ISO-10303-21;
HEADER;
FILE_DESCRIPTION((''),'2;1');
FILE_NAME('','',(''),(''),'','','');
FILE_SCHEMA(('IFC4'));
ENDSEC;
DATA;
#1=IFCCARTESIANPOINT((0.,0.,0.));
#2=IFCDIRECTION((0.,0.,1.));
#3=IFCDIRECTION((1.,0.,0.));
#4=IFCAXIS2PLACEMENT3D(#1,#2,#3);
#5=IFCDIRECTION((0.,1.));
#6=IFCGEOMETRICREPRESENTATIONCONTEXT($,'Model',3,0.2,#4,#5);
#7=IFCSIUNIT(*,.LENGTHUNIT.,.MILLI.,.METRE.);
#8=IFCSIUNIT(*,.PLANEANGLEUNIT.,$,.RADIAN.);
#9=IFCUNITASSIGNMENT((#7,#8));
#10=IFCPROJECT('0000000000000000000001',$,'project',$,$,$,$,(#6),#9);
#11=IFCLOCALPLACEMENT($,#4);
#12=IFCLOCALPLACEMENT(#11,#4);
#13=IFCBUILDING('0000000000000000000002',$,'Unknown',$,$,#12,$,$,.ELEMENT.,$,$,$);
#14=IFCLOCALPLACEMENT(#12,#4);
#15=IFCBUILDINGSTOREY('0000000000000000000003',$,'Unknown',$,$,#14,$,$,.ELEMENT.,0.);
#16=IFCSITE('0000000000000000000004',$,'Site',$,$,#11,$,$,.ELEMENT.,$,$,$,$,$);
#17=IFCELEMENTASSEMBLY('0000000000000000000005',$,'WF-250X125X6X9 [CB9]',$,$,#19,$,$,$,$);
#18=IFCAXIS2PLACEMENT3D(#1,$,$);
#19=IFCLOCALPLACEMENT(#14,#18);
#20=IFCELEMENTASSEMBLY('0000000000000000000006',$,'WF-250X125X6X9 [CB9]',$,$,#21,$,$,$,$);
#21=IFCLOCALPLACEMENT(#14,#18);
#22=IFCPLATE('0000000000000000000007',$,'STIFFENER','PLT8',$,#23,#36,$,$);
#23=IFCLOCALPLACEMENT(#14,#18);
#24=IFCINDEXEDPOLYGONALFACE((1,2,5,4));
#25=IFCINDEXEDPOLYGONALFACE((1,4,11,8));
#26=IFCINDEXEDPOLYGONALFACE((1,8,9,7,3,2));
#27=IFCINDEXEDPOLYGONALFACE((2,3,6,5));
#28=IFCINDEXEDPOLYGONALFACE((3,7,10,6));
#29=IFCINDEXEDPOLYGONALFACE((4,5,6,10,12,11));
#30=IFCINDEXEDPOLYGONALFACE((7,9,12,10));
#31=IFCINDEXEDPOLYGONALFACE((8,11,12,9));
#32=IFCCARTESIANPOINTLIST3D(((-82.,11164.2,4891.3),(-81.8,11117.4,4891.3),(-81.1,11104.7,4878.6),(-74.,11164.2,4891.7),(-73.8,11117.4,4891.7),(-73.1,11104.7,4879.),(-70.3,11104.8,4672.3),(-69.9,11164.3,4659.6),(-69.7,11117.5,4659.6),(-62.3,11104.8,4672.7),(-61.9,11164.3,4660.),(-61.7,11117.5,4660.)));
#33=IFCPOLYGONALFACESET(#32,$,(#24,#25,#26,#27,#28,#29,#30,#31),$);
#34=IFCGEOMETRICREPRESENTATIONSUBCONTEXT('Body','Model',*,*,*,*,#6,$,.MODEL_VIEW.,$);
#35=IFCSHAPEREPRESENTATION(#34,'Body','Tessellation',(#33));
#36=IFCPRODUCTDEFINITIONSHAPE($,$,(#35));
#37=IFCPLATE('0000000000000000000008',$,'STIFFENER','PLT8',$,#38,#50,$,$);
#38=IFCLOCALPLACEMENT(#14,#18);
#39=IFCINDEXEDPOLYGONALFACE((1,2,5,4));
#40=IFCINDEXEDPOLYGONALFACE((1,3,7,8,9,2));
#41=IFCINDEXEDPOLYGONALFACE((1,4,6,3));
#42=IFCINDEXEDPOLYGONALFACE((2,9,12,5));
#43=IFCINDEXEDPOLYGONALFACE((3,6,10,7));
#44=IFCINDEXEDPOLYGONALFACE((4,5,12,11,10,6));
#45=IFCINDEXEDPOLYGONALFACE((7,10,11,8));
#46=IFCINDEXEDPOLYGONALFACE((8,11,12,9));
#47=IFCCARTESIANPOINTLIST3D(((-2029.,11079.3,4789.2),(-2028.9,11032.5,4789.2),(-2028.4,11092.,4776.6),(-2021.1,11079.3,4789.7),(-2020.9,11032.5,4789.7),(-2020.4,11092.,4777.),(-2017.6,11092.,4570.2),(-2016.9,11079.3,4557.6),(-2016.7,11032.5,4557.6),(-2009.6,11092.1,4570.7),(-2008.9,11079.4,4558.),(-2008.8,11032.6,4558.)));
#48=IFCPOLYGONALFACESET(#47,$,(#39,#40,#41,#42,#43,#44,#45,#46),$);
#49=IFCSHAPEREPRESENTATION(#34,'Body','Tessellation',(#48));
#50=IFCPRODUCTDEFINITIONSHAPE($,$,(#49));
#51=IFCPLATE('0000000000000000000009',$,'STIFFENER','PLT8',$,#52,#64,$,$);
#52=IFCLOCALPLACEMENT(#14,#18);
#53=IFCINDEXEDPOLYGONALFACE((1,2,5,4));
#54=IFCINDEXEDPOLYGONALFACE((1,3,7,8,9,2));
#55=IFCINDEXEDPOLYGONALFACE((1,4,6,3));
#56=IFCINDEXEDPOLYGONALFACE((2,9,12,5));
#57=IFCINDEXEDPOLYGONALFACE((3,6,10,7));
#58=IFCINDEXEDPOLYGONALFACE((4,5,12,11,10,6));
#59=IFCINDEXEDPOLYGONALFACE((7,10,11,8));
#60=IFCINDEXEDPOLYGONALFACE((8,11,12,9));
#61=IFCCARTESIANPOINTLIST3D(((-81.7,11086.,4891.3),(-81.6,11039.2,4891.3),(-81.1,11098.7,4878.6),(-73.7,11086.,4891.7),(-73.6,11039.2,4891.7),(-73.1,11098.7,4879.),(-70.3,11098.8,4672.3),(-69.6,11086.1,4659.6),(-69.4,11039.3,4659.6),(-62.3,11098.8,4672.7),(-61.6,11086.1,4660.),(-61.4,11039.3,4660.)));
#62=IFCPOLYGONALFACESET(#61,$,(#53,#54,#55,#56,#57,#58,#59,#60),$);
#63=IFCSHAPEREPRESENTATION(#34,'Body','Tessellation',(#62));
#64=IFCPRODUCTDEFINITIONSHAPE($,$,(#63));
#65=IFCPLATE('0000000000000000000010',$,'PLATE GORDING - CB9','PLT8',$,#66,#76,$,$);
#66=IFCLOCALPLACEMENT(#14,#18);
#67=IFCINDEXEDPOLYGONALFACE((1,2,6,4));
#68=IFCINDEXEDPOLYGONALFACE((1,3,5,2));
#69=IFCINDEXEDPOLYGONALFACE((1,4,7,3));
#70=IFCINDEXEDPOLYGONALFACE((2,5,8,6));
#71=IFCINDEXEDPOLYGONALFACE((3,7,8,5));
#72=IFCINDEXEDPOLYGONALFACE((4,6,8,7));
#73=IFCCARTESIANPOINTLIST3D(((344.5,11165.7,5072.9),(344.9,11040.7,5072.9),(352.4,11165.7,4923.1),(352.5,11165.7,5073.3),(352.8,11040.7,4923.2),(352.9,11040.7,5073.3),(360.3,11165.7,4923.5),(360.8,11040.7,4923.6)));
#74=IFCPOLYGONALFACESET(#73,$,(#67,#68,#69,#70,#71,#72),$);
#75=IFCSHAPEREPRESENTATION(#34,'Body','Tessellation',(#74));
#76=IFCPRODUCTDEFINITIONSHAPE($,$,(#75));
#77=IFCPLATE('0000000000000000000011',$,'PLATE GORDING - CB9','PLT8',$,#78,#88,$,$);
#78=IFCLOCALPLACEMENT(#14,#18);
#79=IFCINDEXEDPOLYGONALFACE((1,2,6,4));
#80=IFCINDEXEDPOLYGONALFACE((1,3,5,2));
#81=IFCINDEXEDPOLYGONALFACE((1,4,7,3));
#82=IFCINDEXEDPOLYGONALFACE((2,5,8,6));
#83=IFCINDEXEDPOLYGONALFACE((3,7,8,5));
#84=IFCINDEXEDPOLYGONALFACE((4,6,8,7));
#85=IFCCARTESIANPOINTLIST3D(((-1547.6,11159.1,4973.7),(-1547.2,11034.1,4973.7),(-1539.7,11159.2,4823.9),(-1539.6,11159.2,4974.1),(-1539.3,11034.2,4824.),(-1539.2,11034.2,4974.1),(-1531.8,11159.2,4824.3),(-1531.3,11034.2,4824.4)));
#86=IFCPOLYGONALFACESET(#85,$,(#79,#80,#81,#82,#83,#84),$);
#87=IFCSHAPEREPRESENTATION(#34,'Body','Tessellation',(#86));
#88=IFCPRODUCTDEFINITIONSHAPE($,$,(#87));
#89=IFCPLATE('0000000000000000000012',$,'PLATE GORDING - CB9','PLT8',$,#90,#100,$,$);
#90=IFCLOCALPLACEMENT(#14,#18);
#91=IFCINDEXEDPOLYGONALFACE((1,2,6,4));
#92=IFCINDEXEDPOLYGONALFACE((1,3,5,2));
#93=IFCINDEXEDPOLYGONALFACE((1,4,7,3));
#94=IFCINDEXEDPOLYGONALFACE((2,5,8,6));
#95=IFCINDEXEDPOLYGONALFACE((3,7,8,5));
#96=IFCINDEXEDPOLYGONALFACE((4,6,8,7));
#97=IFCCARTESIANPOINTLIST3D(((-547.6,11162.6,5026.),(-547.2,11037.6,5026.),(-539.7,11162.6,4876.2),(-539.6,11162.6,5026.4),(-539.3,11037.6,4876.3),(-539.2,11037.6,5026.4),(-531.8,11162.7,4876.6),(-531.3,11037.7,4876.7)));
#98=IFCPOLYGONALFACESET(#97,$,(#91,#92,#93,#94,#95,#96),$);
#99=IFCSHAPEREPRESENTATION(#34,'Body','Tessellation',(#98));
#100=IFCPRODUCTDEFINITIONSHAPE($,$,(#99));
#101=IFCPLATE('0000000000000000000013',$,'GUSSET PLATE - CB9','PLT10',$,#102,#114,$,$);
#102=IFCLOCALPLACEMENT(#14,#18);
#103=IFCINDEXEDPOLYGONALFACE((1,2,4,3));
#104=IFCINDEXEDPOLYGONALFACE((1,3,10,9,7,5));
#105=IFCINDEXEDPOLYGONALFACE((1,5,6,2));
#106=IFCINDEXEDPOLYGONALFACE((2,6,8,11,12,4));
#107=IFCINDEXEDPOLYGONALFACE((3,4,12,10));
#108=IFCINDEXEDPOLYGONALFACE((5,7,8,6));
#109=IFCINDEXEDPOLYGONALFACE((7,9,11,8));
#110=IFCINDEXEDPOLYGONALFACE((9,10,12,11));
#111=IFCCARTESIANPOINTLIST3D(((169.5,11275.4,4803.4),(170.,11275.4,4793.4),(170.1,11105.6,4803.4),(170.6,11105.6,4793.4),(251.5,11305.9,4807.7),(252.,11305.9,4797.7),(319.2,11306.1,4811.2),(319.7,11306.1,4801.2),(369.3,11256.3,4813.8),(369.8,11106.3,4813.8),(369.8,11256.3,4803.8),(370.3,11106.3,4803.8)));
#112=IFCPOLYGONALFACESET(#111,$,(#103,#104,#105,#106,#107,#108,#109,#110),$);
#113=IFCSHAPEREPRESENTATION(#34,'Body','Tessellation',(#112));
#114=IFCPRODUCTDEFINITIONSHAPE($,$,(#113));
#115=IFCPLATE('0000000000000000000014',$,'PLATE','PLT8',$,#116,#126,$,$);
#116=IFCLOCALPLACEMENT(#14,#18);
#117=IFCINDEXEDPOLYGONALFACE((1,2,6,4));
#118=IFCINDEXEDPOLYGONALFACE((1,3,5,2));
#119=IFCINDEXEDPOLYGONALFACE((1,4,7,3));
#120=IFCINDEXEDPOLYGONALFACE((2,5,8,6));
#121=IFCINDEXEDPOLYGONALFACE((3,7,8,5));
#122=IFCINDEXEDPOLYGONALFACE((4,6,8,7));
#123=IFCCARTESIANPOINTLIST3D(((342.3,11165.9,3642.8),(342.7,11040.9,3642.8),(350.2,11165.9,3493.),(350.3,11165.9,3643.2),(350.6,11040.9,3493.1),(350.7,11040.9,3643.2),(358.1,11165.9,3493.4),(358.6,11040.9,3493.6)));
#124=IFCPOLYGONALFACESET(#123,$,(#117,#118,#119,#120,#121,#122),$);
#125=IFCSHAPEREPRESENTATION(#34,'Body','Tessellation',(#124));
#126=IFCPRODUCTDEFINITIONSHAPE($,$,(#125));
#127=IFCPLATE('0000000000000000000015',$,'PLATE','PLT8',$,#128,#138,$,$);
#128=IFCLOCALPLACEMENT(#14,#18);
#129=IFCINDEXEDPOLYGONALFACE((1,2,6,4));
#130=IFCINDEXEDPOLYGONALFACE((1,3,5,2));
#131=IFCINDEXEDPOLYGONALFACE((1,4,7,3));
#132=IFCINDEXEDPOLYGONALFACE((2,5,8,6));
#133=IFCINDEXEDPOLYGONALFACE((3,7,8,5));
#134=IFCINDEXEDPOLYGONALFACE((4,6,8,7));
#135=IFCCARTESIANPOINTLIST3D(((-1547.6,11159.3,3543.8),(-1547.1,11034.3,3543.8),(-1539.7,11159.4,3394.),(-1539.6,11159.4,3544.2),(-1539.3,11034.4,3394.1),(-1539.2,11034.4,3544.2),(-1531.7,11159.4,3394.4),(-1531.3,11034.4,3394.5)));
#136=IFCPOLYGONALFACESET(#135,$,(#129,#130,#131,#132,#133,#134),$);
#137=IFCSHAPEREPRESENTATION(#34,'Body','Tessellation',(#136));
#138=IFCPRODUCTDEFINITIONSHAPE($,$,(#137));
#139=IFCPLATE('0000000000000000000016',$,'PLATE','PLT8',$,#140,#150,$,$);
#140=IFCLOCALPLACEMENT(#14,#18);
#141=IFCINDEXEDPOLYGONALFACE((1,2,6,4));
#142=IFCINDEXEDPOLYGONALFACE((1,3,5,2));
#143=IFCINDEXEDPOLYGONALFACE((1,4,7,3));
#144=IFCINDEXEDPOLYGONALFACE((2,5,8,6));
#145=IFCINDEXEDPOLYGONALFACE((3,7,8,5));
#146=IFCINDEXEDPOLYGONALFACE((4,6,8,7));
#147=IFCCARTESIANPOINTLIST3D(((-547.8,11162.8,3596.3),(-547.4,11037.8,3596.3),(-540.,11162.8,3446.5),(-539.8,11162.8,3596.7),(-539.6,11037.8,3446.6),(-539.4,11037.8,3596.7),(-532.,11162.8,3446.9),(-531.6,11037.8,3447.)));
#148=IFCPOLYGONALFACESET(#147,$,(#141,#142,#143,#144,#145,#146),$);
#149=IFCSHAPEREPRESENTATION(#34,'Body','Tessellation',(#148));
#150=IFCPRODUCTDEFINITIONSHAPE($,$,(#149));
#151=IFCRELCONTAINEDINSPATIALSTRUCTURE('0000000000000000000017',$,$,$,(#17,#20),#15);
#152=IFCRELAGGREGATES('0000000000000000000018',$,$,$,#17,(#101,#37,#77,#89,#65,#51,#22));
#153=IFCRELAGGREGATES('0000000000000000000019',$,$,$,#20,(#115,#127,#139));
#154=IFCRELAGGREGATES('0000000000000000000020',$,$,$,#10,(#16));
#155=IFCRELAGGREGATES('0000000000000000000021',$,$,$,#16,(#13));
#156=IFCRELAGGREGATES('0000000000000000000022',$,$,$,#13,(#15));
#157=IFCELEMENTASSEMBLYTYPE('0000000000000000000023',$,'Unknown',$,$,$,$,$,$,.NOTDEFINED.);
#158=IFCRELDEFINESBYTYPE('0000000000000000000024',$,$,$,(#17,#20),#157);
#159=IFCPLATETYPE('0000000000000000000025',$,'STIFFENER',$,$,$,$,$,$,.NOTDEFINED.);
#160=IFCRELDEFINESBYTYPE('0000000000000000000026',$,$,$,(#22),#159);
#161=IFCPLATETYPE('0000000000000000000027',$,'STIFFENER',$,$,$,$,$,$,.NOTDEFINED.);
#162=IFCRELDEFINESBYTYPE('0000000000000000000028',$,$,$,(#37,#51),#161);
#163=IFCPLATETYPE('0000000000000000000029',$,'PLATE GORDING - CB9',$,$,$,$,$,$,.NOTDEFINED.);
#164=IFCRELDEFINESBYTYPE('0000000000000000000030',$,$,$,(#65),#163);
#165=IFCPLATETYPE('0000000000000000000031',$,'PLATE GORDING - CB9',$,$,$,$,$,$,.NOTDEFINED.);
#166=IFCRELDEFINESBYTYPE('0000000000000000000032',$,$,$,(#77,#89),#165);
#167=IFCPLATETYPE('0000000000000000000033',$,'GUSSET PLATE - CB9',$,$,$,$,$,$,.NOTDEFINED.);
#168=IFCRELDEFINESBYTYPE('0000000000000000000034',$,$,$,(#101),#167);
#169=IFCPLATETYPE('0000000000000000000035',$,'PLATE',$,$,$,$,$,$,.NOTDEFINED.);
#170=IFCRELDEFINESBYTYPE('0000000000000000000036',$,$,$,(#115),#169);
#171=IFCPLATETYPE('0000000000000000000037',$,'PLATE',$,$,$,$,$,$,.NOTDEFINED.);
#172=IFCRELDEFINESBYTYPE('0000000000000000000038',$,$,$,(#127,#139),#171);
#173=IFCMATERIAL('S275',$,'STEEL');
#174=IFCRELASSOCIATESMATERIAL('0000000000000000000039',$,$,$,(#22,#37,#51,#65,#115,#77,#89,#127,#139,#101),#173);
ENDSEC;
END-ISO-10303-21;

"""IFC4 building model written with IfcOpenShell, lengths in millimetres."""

from ifc_helpers import new_model, si_unit, direction, frame, origin_with_axes, place, context, subcontext, project, spatial, line, indexed_curve, outline, extrude, material, material_profile, profile_set, profile_usage, type_object, element, aggregate, save


model = new_model("IFC4")

# Units and contexts
model_context = context("Model", 3, precision=0.2, world=origin_with_axes(), true_north=direction((0.0, 1.0)))
body_context = subcontext(model_context, "Body", "Model", "MODEL_VIEW")
ifc_project = project(units=[si_unit("LENGTHUNIT", "METRE", prefix="MILLI"), si_unit("PLANEANGLEUNIT", "RADIAN")], contexts=[model_context])

# Site, building, storey
site_placement = place(None, origin_with_axes())
site = spatial("IfcSite", under=ifc_project, at=site_placement, Name="Site", CompositionType="ELEMENT")
building_placement = place(site_placement, origin_with_axes())
building = spatial("IfcBuilding", under=site, at=building_placement, Name="Unknown", CompositionType="ELEMENT")
storey_placement = place(building_placement, origin_with_axes())
storey = spatial("IfcBuildingStorey", under=building, at=storey_placement, Name="Unknown", CompositionType="ELEMENT", Elevation=0.0)

# Shared definitions
element_assembly_type = type_object("IfcElementAssemblyType", Name="Unknown", PredefinedType="NOTDEFINED")
ifc_material_1 = material(Name="S275", Category="STEEL")

# Element assembly
assembly_1_placement = place(storey_placement, frame((-2227.5, 11094.3, 4662.7), z_axis=(0.003456, -0.999994, 0.0), x_axis=(0.998624, 0.003452, 0.052336)))
assembly_1 = element("IfcElementAssembly", 1, at=assembly_1_placement, inside=storey, type_object=element_assembly_type, Name="WF-250X125X6X9 [CB9]")

# Element assembly
assembly_2_placement = place(storey_placement, frame((-2191.6, 11094.6, 3234.7), z_axis=(-0.003456, 0.999994, 0.0), x_axis=(0.998601, 0.003452, 0.052758)))
assembly_2 = element("IfcElementAssembly", 2, at=assembly_2_placement, inside=storey, type_object=element_assembly_type, Name="WF-250X125X6X9 [CB9]")

# Plates
ifc_material_profile_1 = material_profile(ifc_material_1, outline(indexed_curve([(0.0, 12.7), (12.7, 0.0), (59.5, 0.0), (59.5, 232.0), (12.7, 232.0), (0.0, 219.3)], segments=[line(1, 2, 3, 4, 5, 6, 1)])), Name="PLT8")
ifc_profile_set_1 = profile_set([ifc_material_profile_1])
ifc_profile_usage_1 = profile_usage(ifc_profile_set_1, cardinal=2)
plate_type_1 = type_object("IfcPlateType", Name="STIFFENER", PredefinedType="NOTDEFINED")
plate_1_placement = place(assembly_1_placement, frame((2158.7, 116.0, -3.0), z_axis=(-1.0, 0.0, 0.0), x_axis=(0.0, 0.0, -1.0)))
plate_1 = element("IfcPlate", 3, at=plate_1_placement, type_object=plate_type_1, material=ifc_profile_usage_1, Name="STIFFENER", Description="PLT8", context=body_context, shape_type="SolidModel", body=[
    extrude(outline(indexed_curve([(0.0, 12.7), (12.7, 0.0), (59.5, 0.0), (59.5, 232.0), (12.7, 232.0), (0.0, 219.3)], segments=[line(1, 2, 3, 4, 5, 6, 1)])), frame((0.0, 0.0, 4.0), z_axis=(0.0, 0.0, 1.0), x_axis=(1.0, 0.0, 0.0)), (0.0, 0.0, -1.0), 8.0),
])
ifc_material_profile_2 = material_profile(ifc_material_1, outline(indexed_curve([(0.0, 0.0), (46.8, 0.0), (59.5, 12.7), (59.5, 219.3), (46.8, 232.0), (0.0, 232.0)], segments=[line(1, 2, 3, 4, 5, 6, 1)])), Name="PLT8")
ifc_profile_set_2 = profile_set([ifc_material_profile_2])
ifc_profile_usage_2 = profile_usage(ifc_profile_set_2, cardinal=2)
plate_type_2 = type_object("IfcPlateType", Name="STIFFENER", PredefinedType="NOTDEFINED")
plate_2_placement = place(assembly_1_placement, frame((208.7, 116.0, 62.5), z_axis=(-1.0, 0.0, 0.0), x_axis=(0.0, 0.0, -1.0)))
plate_2 = element("IfcPlate", 4, at=plate_2_placement, type_object=plate_type_2, material=ifc_profile_usage_2, Name="STIFFENER", Description="PLT8", context=body_context, shape_type="SolidModel", body=[
    extrude(outline(indexed_curve([(0.0, 0.0), (46.8, 0.0), (59.5, 12.7), (59.5, 219.3), (46.8, 232.0), (0.0, 232.0)], segments=[line(1, 2, 3, 4, 5, 6, 1)])), frame((0.0, 0.0, 4.0), z_axis=(0.0, 0.0, 1.0), x_axis=(1.0, 0.0, 0.0)), (0.0, 0.0, -1.0), 8.0),
])
plate_3_placement = place(assembly_1_placement, frame((2158.7, 116.0, 62.5), z_axis=(-1.0, 0.0, 0.0), x_axis=(0.0, 0.0, -1.0)))
plate_3 = element("IfcPlate", 5, at=plate_3_placement, type_object=plate_type_2, material=ifc_profile_usage_2, Name="STIFFENER", Description="PLT8", context=body_context, shape_type="SolidModel", body=[
    extrude(outline(indexed_curve([(0.0, 0.0), (46.8, 0.0), (59.5, 12.7), (59.5, 219.3), (46.8, 232.0), (0.0, 232.0)], segments=[line(1, 2, 3, 4, 5, 6, 1)])), frame((0.0, 0.0, 4.0), z_axis=(0.0, 0.0, 1.0), x_axis=(1.0, 0.0, 0.0)), (0.0, 0.0, -1.0), 8.0),
])
ifc_material_profile_3 = material_profile(ifc_material_1, outline(indexed_curve([(0.0, 0.0), (125.0, 0.0), (125.0, 149.9), (0.0, 150.0)], segments=[line(1, 2, 3, 4, 1)])), Name="PLT8")
ifc_profile_set_3 = profile_set([ifc_material_profile_3])
ifc_profile_usage_3 = profile_usage(ifc_profile_set_3, cardinal=5)
plate_type_3 = type_object("IfcPlateType", Name="PLATE GORDING - CB9", PredefinedType="NOTDEFINED")
plate_4_placement = place(assembly_1_placement, frame((2594.2, 275.0, -62.5), z_axis=(1.0, 0.0, 0.0), x_axis=(0.0, 0.0, 1.0)))
plate_4 = element("IfcPlate", 6, at=plate_4_placement, type_object=plate_type_3, material=ifc_profile_usage_3, Name="PLATE GORDING - CB9", Description="PLT8", context=body_context, shape_type="SolidModel", body=[
    extrude(outline(indexed_curve([(0.0, 0.0), (125.0, 0.0), (125.0, 149.9), (0.0, 150.0)], segments=[line(1, 2, 3, 4, 1)])), frame((0.0, 0.0, 4.0), z_axis=(0.0, 0.0, 1.0), x_axis=(1.0, 0.0, 0.0)), (0.0, 0.0, -1.0), 8.0),
])
ifc_material_profile_4 = material_profile(ifc_material_1, outline(indexed_curve([(0.0, 0.0), (149.9, 0.0), (150.0, 125.0), (0.0, 125.0)], segments=[line(1, 2, 3, 4, 1)])), Name="PLT8")
ifc_profile_set_4 = profile_set([ifc_material_profile_4])
ifc_profile_usage_4 = profile_usage(ifc_profile_set_4, cardinal=5)
plate_type_4 = type_object("IfcPlateType", Name="PLATE GORDING - CB9", PredefinedType="NOTDEFINED")
plate_5_placement = place(assembly_1_placement, frame((699.4, 275.0, 62.5), z_axis=(1.0, 0.0, 0.0), x_axis=(0.0, -1.0, 0.0)))
plate_5 = element("IfcPlate", 7, at=plate_5_placement, type_object=plate_type_4, material=ifc_profile_usage_4, Name="PLATE GORDING - CB9", Description="PLT8", context=body_context, shape_type="SolidModel", body=[
    extrude(outline(indexed_curve([(0.0, 0.0), (149.9, 0.0), (150.0, 125.0), (0.0, 125.0)], segments=[line(1, 2, 3, 4, 1)])), frame((0.0, 0.0, 4.0), z_axis=(0.0, 0.0, 1.0), x_axis=(1.0, 0.0, 0.0)), (0.0, 0.0, -1.0), 8.0),
])
plate_6_placement = place(assembly_1_placement, frame((1700.8, 274.9, 62.5), z_axis=(1.0, 0.0, 0.0), x_axis=(0.0, -1.0, 0.0)))
plate_6 = element("IfcPlate", 8, at=plate_6_placement, type_object=plate_type_4, material=ifc_profile_usage_4, Name="PLATE GORDING - CB9", Description="PLT8", context=body_context, shape_type="SolidModel", body=[
    extrude(outline(indexed_curve([(0.0, 0.0), (149.9, 0.0), (150.0, 125.0), (0.0, 125.0)], segments=[line(1, 2, 3, 4, 1)])), frame((0.0, 0.0, 4.0), z_axis=(0.0, 0.0, 1.0), x_axis=(1.0, 0.0, 0.0)), (0.0, 0.0, -1.0), 8.0),
])
ifc_material_profile_5 = material_profile(ifc_material_1, outline(indexed_curve([(0.0, 0.0), (169.8, 0.0), (200.0, 82.2), (200.0, 150.0), (150.0, 200.0), (0.0, 200.0)], segments=[line(1, 2, 3, 4, 5, 6, 1)])), Name="PLT10")
ifc_profile_set_5 = profile_set([ifc_material_profile_5])
ifc_profile_usage_5 = profile_usage(ifc_profile_set_5, cardinal=5)
plate_type_5 = type_object("IfcPlateType", Name="GUSSET PLATE - CB9", PredefinedType="NOTDEFINED")
plate_7_placement = place(assembly_1_placement, frame((2401.7, 10.0, -3.0), z_axis=(0.0, -1.0, 0.0), x_axis=(0.0, 0.0, -1.0)))
plate_7 = element("IfcPlate", 9, at=plate_7_placement, type_object=plate_type_5, material=ifc_profile_usage_5, Name="GUSSET PLATE - CB9", Description="PLT10", context=body_context, shape_type="SolidModel", body=[
    extrude(outline(indexed_curve([(0.0, 0.0), (169.8, 0.0), (200.0, 82.2), (200.0, 150.0), (150.0, 200.0), (0.0, 200.0)], segments=[line(1, 2, 3, 4, 5, 6, 1)])), frame((0.0, 0.0, 5.0), z_axis=(0.0, 0.0, 1.0), x_axis=(1.0, 0.0, 0.0)), (0.0, 0.0, -1.0), 10.0),
])
aggregate(assembly_1, [plate_7, plate_2, plate_5, plate_6, plate_4, plate_3, plate_1])
plate_type_6 = type_object("IfcPlateType", Name="PLATE", PredefinedType="NOTDEFINED")
plate_8_placement = place(assembly_2_placement, frame((2556.1, -273.8, 62.5), z_axis=(1.0, 0.000422, 0.0), x_axis=(0.0, 0.0, -1.0)))
plate_8 = element("IfcPlate", 10, at=plate_8_placement, type_object=plate_type_6, material=ifc_profile_usage_3, Name="PLATE", Description="PLT8", context=body_context, shape_type="SolidModel", body=[
    extrude(outline(indexed_curve([(0.0, 0.0), (125.0, 0.0), (125.0, 149.9), (0.0, 150.0)], segments=[line(1, 2, 3, 4, 1)])), frame((0.0, 0.0, 4.0), z_axis=(0.0, 0.0, 1.0), x_axis=(1.0, 0.0, 0.0)), (0.0, 0.0, -1.0), 8.0),
])
plate_type_7 = type_object("IfcPlateType", Name="PLATE", PredefinedType="NOTDEFINED")
plate_9_placement = place(assembly_2_placement, frame((663.6, -274.6, -62.5), z_axis=(1.0, 0.000422, 0.0), x_axis=(-0.000422, 1.0, 0.0)))
plate_9 = element("IfcPlate", 11, at=plate_9_placement, type_object=plate_type_7, material=ifc_profile_usage_4, Name="PLATE", Description="PLT8", context=body_context, shape_type="SolidModel", body=[
    extrude(outline(indexed_curve([(0.0, 0.0), (149.9, 0.0), (150.0, 125.0), (0.0, 125.0)], segments=[line(1, 2, 3, 4, 1)])), frame((0.0, 0.0, 4.0), z_axis=(0.0, 0.0, 1.0), x_axis=(1.0, 0.0, 0.0)), (0.0, 0.0, -1.0), 8.0),
])
plate_10_placement = place(assembly_2_placement, frame((1664.8, -274.3, -62.5), z_axis=(1.0, 0.000422, 0.0), x_axis=(-0.000422, 1.0, 0.0)))
plate_10 = element("IfcPlate", 12, at=plate_10_placement, type_object=plate_type_7, material=ifc_profile_usage_4, Name="PLATE", Description="PLT8", context=body_context, shape_type="SolidModel", body=[
    extrude(outline(indexed_curve([(0.0, 0.0), (149.9, 0.0), (150.0, 125.0), (0.0, 125.0)], segments=[line(1, 2, 3, 4, 1)])), frame((0.0, 0.0, 4.0), z_axis=(0.0, 0.0, 1.0), x_axis=(1.0, 0.0, 0.0)), (0.0, 0.0, -1.0), 8.0),
])
aggregate(assembly_2, [plate_8, plate_9, plate_10])

save(model, "model.ifc")
